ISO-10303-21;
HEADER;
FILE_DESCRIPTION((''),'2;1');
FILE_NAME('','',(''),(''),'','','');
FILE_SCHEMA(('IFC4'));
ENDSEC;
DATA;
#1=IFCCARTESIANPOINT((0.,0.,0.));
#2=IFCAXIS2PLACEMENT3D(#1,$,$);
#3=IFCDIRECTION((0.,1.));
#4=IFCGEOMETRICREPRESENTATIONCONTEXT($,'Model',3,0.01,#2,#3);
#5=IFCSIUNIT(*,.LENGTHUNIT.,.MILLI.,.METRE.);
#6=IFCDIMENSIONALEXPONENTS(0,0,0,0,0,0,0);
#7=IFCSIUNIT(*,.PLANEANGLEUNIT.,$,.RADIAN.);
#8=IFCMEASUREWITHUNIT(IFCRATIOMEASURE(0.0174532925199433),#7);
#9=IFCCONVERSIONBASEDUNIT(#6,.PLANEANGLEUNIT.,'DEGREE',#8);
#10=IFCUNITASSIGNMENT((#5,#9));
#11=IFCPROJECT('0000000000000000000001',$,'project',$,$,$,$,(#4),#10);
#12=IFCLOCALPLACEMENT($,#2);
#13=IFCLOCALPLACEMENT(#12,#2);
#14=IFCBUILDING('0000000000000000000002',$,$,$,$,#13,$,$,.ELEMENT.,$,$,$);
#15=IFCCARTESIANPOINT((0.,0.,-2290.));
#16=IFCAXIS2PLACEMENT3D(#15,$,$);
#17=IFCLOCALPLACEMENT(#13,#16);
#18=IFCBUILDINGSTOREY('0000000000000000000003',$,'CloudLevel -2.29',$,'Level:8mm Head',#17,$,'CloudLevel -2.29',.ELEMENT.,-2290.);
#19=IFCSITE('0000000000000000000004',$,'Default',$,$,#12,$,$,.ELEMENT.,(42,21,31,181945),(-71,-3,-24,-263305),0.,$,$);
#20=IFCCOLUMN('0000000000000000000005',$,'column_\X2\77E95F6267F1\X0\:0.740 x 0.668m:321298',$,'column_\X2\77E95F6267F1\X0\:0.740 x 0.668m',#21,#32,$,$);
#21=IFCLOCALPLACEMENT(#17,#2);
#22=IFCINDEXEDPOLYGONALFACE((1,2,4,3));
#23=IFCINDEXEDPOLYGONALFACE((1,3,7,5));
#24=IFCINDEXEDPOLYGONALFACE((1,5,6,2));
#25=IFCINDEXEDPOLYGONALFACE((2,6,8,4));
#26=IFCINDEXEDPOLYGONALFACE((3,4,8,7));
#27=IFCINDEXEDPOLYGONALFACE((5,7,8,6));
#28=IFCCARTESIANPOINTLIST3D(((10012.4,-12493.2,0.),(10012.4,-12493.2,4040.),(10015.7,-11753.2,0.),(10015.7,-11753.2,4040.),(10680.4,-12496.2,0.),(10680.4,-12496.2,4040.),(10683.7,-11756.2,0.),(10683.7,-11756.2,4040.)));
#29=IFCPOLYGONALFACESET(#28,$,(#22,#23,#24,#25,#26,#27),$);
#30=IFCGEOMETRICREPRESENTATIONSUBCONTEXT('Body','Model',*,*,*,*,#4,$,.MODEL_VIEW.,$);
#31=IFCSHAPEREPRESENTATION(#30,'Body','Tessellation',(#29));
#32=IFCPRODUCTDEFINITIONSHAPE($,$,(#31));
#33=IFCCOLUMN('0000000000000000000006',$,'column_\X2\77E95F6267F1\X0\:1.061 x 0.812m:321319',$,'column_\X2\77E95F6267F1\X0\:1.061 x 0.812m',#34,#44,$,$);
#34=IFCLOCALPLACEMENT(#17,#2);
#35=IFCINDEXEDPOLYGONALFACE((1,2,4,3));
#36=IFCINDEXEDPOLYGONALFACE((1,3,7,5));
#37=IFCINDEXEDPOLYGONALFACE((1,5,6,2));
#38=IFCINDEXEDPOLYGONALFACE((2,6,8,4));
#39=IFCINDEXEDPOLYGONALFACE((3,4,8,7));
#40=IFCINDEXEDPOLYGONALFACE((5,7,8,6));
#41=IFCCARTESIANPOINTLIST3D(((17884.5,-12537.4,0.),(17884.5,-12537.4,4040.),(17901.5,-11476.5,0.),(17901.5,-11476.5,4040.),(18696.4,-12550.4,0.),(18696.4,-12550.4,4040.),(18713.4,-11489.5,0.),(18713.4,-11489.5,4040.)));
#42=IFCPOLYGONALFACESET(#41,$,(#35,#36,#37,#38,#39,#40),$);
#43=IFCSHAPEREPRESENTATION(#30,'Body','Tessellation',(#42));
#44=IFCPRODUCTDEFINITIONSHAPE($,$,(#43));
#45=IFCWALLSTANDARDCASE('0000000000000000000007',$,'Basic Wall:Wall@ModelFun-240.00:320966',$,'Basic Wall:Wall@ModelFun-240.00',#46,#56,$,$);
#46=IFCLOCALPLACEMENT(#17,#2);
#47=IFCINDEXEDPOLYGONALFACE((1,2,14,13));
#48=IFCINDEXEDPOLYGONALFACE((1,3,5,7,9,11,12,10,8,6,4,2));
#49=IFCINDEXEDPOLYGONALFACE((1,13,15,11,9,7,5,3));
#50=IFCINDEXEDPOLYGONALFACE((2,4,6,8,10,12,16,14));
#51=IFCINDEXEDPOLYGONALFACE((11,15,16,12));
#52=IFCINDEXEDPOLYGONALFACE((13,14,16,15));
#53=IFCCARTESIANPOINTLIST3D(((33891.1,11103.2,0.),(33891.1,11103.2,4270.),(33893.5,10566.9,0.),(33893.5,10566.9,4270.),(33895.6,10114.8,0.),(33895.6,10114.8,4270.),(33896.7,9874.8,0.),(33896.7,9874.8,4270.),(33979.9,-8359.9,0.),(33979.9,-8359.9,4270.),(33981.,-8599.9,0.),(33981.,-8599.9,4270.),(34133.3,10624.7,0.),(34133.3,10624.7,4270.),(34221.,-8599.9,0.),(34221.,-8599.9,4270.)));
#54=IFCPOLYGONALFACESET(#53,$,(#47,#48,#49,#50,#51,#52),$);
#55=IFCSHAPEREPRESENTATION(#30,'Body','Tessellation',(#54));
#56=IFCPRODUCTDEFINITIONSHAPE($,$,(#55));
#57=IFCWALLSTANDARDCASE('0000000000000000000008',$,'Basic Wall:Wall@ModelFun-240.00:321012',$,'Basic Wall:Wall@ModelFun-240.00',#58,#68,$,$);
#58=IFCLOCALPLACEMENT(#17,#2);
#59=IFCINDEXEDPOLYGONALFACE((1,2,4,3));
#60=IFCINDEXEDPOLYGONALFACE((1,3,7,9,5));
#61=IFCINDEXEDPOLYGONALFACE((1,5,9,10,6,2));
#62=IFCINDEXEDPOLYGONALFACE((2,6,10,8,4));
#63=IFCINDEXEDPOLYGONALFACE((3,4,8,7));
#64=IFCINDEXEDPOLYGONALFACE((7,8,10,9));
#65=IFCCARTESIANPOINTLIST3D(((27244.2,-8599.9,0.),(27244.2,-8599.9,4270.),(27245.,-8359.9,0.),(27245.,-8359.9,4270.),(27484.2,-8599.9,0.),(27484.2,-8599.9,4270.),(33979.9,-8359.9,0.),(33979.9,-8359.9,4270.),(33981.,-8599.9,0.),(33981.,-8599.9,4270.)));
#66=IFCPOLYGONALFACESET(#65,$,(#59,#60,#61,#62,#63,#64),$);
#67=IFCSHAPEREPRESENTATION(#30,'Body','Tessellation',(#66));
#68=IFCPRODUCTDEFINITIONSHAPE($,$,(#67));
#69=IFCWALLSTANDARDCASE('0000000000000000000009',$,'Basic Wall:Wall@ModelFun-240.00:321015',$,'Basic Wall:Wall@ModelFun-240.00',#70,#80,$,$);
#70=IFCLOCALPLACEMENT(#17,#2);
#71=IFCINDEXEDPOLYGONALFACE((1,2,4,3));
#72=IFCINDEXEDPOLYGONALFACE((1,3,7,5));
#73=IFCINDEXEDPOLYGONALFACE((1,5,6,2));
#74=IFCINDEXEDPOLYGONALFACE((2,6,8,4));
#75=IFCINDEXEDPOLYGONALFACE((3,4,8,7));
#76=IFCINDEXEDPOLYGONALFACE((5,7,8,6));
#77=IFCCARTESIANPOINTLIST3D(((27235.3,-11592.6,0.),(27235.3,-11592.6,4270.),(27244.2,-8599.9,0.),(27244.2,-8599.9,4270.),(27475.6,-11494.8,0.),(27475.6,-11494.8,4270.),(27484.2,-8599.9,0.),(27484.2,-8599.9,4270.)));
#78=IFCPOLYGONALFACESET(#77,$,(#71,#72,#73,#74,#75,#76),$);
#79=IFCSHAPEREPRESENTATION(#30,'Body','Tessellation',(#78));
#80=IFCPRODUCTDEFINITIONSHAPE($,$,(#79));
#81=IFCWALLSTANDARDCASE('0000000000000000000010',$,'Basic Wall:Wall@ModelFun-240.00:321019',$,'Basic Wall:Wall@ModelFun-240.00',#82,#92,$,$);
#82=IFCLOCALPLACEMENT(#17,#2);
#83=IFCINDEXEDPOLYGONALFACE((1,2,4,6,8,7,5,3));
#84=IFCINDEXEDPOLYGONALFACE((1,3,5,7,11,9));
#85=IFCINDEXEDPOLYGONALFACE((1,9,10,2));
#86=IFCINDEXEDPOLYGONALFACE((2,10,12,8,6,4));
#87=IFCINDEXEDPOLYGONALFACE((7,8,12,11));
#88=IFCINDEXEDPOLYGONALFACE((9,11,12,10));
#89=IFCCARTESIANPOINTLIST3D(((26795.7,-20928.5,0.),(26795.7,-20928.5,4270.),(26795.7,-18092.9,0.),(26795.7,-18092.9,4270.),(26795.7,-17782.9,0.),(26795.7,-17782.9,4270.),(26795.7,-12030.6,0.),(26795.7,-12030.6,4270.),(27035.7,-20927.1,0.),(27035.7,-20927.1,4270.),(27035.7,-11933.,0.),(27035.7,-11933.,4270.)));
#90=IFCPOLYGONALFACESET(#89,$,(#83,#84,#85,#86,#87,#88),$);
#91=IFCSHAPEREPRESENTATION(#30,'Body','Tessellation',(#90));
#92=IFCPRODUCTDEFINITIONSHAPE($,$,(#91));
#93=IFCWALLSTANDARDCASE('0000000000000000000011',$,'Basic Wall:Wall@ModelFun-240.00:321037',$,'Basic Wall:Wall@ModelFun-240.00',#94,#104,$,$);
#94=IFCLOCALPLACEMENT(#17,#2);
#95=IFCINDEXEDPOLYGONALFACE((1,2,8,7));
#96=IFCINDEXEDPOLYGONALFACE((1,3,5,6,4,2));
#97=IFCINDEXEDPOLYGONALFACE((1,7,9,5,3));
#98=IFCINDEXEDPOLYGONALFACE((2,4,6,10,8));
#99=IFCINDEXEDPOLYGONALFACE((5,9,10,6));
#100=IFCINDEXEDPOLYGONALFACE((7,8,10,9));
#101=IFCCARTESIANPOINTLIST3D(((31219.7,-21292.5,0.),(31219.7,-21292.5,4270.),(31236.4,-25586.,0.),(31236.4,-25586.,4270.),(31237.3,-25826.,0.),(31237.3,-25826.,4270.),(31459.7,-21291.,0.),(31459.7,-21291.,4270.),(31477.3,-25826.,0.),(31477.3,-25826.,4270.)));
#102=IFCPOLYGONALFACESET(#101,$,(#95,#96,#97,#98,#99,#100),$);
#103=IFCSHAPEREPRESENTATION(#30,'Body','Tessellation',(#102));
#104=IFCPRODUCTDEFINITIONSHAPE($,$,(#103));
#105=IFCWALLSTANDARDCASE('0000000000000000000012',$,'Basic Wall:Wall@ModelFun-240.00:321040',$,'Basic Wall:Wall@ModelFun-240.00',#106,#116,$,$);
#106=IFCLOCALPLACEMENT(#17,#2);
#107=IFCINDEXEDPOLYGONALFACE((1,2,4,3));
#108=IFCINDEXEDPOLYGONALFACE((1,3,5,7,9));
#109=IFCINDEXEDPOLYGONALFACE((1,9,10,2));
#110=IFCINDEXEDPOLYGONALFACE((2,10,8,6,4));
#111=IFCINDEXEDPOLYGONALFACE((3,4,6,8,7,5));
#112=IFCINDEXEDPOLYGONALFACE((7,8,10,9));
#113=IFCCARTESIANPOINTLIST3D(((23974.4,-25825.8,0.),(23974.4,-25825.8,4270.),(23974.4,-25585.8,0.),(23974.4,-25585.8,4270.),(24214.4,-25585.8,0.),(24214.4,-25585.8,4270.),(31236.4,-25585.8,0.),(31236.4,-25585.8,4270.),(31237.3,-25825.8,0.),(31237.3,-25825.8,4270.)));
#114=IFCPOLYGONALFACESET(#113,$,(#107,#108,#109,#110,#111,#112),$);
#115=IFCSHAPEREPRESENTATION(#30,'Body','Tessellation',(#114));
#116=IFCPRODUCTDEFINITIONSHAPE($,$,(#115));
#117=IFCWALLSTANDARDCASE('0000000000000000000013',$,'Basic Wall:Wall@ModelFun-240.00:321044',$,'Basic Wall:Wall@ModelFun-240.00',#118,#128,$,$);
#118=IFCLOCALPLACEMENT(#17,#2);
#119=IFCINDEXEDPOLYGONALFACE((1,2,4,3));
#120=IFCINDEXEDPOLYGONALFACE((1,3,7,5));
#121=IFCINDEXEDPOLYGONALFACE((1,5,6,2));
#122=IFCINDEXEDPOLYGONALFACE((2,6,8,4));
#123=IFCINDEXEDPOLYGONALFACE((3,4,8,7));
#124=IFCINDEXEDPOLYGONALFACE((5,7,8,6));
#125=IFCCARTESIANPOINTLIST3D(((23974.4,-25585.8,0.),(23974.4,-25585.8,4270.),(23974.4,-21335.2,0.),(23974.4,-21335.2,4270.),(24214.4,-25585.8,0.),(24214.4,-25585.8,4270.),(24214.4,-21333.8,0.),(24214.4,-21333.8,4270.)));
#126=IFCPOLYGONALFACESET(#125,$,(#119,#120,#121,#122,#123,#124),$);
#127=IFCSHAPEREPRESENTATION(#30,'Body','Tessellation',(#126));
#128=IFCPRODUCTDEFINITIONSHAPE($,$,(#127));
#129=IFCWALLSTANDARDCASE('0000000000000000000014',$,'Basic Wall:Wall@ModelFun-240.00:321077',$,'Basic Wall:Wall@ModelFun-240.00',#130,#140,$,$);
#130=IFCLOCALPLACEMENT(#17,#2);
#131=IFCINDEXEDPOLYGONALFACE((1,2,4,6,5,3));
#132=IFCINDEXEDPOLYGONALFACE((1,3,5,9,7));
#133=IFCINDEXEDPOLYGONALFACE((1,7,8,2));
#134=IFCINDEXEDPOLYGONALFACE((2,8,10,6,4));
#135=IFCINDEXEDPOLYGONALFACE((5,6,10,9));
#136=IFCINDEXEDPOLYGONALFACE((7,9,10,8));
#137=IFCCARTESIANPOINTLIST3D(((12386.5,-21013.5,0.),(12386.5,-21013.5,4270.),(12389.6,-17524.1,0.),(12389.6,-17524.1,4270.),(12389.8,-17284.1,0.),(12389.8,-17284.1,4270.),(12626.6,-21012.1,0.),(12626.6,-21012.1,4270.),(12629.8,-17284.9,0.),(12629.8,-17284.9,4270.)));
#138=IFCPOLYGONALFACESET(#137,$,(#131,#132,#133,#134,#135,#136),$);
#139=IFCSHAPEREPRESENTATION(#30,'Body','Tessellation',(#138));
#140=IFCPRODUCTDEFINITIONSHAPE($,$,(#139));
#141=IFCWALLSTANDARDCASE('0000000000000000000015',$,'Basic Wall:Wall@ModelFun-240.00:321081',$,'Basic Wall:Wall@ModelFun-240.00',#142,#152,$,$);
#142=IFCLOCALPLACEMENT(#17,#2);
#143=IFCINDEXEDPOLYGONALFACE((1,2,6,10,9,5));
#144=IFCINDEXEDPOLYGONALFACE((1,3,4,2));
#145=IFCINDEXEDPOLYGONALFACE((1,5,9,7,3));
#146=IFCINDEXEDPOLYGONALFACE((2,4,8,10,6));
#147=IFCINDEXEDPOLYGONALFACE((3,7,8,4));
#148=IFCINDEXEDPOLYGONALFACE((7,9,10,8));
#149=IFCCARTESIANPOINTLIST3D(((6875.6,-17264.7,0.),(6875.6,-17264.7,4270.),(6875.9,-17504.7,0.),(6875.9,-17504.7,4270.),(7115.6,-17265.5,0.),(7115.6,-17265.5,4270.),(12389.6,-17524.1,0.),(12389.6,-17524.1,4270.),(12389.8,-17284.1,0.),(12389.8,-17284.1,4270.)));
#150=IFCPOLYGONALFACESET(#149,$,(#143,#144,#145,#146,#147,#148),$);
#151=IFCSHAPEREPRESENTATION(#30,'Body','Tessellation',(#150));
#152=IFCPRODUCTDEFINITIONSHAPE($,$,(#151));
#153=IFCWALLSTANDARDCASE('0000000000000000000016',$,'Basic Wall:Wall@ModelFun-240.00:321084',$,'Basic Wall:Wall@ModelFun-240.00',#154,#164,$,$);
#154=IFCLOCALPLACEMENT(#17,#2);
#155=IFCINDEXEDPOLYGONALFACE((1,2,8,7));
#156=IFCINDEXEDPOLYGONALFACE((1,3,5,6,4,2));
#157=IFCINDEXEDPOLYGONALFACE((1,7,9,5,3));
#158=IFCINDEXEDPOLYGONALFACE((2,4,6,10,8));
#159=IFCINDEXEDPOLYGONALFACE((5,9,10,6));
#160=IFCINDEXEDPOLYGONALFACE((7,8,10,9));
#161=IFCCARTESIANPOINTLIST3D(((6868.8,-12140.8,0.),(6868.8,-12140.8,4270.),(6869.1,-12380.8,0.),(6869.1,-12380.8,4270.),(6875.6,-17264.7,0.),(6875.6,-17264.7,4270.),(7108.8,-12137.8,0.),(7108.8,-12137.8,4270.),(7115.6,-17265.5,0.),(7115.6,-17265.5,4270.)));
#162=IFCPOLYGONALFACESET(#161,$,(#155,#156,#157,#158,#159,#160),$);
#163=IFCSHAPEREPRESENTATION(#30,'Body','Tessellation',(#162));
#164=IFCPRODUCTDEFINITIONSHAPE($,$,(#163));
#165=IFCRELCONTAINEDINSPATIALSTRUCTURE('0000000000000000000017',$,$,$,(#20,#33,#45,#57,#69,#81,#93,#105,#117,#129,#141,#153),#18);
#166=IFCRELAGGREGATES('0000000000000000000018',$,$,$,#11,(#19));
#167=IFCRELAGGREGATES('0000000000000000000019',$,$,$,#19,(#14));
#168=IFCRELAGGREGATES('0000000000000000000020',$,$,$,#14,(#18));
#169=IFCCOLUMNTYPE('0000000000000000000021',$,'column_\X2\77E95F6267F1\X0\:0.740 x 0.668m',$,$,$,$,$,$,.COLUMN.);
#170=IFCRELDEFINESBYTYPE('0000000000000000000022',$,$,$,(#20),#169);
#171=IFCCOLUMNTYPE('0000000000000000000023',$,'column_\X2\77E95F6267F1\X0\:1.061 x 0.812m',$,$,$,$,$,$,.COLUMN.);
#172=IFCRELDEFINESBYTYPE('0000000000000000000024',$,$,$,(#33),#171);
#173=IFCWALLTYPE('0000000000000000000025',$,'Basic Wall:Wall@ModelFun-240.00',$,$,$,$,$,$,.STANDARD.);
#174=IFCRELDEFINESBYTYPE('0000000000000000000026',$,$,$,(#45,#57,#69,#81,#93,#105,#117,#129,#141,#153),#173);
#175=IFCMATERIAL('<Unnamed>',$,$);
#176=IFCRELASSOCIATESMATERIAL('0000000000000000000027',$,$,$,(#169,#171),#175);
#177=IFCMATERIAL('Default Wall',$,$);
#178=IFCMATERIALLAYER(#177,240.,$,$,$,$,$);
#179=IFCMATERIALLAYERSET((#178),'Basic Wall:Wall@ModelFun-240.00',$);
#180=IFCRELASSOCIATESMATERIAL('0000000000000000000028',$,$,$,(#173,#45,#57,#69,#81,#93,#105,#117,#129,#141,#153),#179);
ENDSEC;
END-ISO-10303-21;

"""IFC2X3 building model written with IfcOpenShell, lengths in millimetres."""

from ifc_helpers import new_model, entity, si_unit, converted_unit, direction, frame, origin, origin_2d_with_axis, place, context, subcontext, project, spatial, polyline, rectangle, outline, extrude, source, transform, mapped, material, layer, layer_set, layer_usage, type_object, type_shapes, element, save


model = new_model("IFC2X3")

# Units and contexts
model_context = context("Model", 3, precision=0.01, world=origin(), true_north=direction((0.0, 1.0)))
body_context = subcontext(model_context, "Body", "Model", "MODEL_VIEW")
ifc_project = project(units=[si_unit("LENGTHUNIT", "METRE", prefix="MILLI"), converted_unit("PLANEANGLEUNIT", "DEGREE", entity("IfcRatioMeasure", 0.0174532925199433), si_unit("PLANEANGLEUNIT", "RADIAN"), dimensions=[0, 0, 0, 0, 0, 0, 0])], contexts=[model_context])

# Site, building, storey
site_placement = place(None, origin())
site = spatial("IfcSite", under=ifc_project, at=site_placement, Name="Default", CompositionType="ELEMENT", RefLatitude=(42, 21, 31, 181945), RefLongitude=(-71, -3, -24, -263305), RefElevation=0.0)
building_placement = place(site_placement, origin())
building = spatial("IfcBuilding", under=site, at=building_placement, CompositionType="ELEMENT")
storey_placement = place(building_placement, frame((0.0, 0.0, -2290.0)))
storey = spatial("IfcBuildingStorey", under=building, at=storey_placement, Name="CloudLevel -2.29", ObjectType="Level:8mm Head", LongName="CloudLevel -2.29", CompositionType="ELEMENT", Elevation=-2290.0)

# Columns
ifc_material_1 = material(Name="<Unnamed>")
column_type_1 = type_object("IfcColumnType", Name="column_矩形柱:0.740 x 0.668m", PredefinedType="COLUMN", material=ifc_material_1)
shared_shape_1 = source(origin(), body_context, "Body", "SweptSolid", [
    extrude(rectangle(XDim=668.0, YDim=740.0, at=origin_2d_with_axis()), frame((0.0, 0.0, -2290.0), z_axis=(0.0, 0.0, 1.0), x_axis=(0.0, -1.0, 0.0)), (0.0, 0.0, 1.0), 4040.0),
])
type_shapes(column_type_1, [shared_shape_1])
column_1_placement = place(storey_placement, frame((10348.0, -12124.7, 2290.0), z_axis=(0.0, 0.0, 1.0), x_axis=(0.004488, 0.99999, 0.0)))
element("IfcColumn", 1, at=column_1_placement, inside=storey, type_object=column_type_1, Name="column_矩形柱:0.740 x 0.668m:321298", ObjectType="column_矩形柱:0.740 x 0.668m", context=body_context, shape_type="MappedRepresentation", body=[
    mapped(shared_shape_1, transform((0.0, 0.0, 0.0), scale=1.0)),
])
column_type_2 = type_object("IfcColumnType", Name="column_矩形柱:1.061 x 0.812m", PredefinedType="COLUMN", material=ifc_material_1)
shared_shape_2 = source(origin(), body_context, "Body", "SweptSolid", [
    extrude(rectangle(XDim=812.0, YDim=1061.0, at=origin_2d_with_axis()), frame((0.0, 0.0, -2290.0), z_axis=(0.0, 0.0, 1.0), x_axis=(0.0, -1.0, 0.0)), (0.0, 0.0, 1.0), 4040.0),
])
type_shapes(column_type_2, [shared_shape_2])
column_2_placement = place(storey_placement, frame((18298.9, -12013.4, 2290.0), z_axis=(0.0, 0.0, 1.0), x_axis=(0.01605, 0.999871, 0.0)))
element("IfcColumn", 2, at=column_2_placement, inside=storey, type_object=column_type_2, Name="column_矩形柱:1.061 x 0.812m:321319", ObjectType="column_矩形柱:1.061 x 0.812m", context=body_context, shape_type="MappedRepresentation", body=[
    mapped(shared_shape_2, transform((0.0, 0.0, 0.0), scale=1.0)),
])

# Walls
ifc_material_2 = material(Name="Default Wall")
ifc_layer_1 = layer(ifc_material_2, 240.0)
ifc_layer_set_1 = layer_set([ifc_layer_1], Name="Basic Wall:Wall@ModelFun-240.00")
ifc_layer_usage_1 = layer_usage(ifc_layer_set_1, "AXIS2", "NEGATIVE", 120.0)
wall_type_1 = type_object("IfcWallType", Name="Basic Wall:Wall@ModelFun-240.00", PredefinedType="STANDARD", material=ifc_layer_set_1)
wall_1_placement = place(storey_placement, frame((34101.0, -8600.4, 0.0), z_axis=(0.0, 0.0, 1.0), x_axis=(-0.004564, 0.99999, 0.0)))
element("IfcWallStandardCase", 3, at=wall_1_placement, inside=storey, type_object=wall_type_1, material=ifc_layer_usage_1, Name="Basic Wall:Wall@ModelFun-240.00:320966", ObjectType="Basic Wall:Wall@ModelFun-240.00", context=body_context, shape_type="SweptSolid", body=[
    extrude(outline(polyline([(19224.8, -120.0), (19704.4, 120.0), (19168.1, 120.0), (18716.0, 120.0), (18476.0, 120.0), (241.1, 120.0), (1.1, 120.0), (0.0, -120.0), (19224.8, -120.0)])), origin(), (0.0, 0.0, 1.0), 4270.0),
])
ifc_layer_usage_2 = layer_usage(ifc_layer_set_1, "AXIS2", "NEGATIVE", 120.0)
wall_2_placement = place(storey_placement, frame((33981.0, -8479.9, 0.0), z_axis=(0.0, 0.0, 1.0), x_axis=(-1.0, 0.0, 0.0)))
element("IfcWallStandardCase", 4, at=wall_2_placement, inside=storey, type_object=wall_type_1, material=ifc_layer_usage_2, Name="Basic Wall:Wall@ModelFun-240.00:321012", ObjectType="Basic Wall:Wall@ModelFun-240.00", context=body_context, shape_type="SweptSolid", body=[
    extrude(outline(polyline([(6736.0, -120.0), (6736.8, 120.0), (6496.8, 120.0), (0.0, 120.0), (1.1, -120.0), (6736.0, -120.0)])), origin(), (0.0, 0.0, 1.0), 4270.0),
])
ifc_layer_usage_3 = layer_usage(ifc_layer_set_1, "AXIS2", "NEGATIVE", 120.0)
wall_3_placement = place(storey_placement, frame((27355.3, -11593.0, 0.0), z_axis=(0.0, 0.0, 1.0), x_axis=(0.002989, 0.999996, 0.0)))
element("IfcWallStandardCase", 5, at=wall_3_placement, inside=storey, type_object=wall_type_1, material=ifc_layer_usage_3, Name="Basic Wall:Wall@ModelFun-240.00:321015", ObjectType="Basic Wall:Wall@ModelFun-240.00", context=body_context, shape_type="SweptSolid", body=[
    extrude(outline(polyline([(2993.4, -120.0), (2992.7, 120.0), (0.0, 120.0), (98.5, -120.0), (2993.4, -120.0)])), origin(), (0.0, 0.0, 1.0), 4270.0),
])
ifc_layer_usage_4 = layer_usage(ifc_layer_set_1, "AXIS2", "NEGATIVE", 120.0)
wall_4_placement = place(storey_placement, frame((26915.7, -20928.5, 0.0), z_axis=(0.0, 0.0, 1.0), x_axis=(0.0, 1.0, 0.0)))
element("IfcWallStandardCase", 6, at=wall_4_placement, inside=storey, type_object=wall_type_1, material=ifc_layer_usage_4, Name="Basic Wall:Wall@ModelFun-240.00:321019", ObjectType="Basic Wall:Wall@ModelFun-240.00", context=body_context, shape_type="SweptSolid", body=[
    extrude(outline(polyline([(8995.6, -120.0), (8897.9, 120.0), (3145.7, 120.0), (2835.7, 120.0), (0.0, 120.0), (1.4, -120.0), (8995.6, -120.0)])), origin(), (0.0, 0.0, 1.0), 4270.0),
])
ifc_layer_usage_5 = layer_usage(ifc_layer_set_1, "AXIS2", "NEGATIVE", 120.0)
wall_5_placement = place(storey_placement, frame((31339.7, -21291.5, 0.0), z_axis=(0.0, 0.0, 1.0), x_axis=(0.00389, -0.999992, 0.0)))
element("IfcWallStandardCase", 7, at=wall_5_placement, inside=storey, type_object=wall_type_1, material=ifc_layer_usage_5, Name="Basic Wall:Wall@ModelFun-240.00:321037", ObjectType="Basic Wall:Wall@ModelFun-240.00", context=body_context, shape_type="SweptSolid", body=[
    extrude(outline(polyline([(4534.1, -120.0), (4535.0, 120.0), (0.0, 120.0), (0.5, -120.0), (4294.1, -120.0), (4534.1, -120.0)])), origin(), (0.0, 0.0, 1.0), 4270.0),
])
ifc_layer_usage_6 = layer_usage(ifc_layer_set_1, "AXIS2", "NEGATIVE", 120.0)
wall_6_placement = place(storey_placement, frame((23974.4, -25705.8, 0.0)))
element("IfcWallStandardCase", 8, at=wall_6_placement, inside=storey, type_object=wall_type_1, material=ifc_layer_usage_6, Name="Basic Wall:Wall@ModelFun-240.00:321040", ObjectType="Basic Wall:Wall@ModelFun-240.00", context=body_context, shape_type="SweptSolid", body=[
    extrude(outline(polyline([(7263.0, -120.0), (7262.0, 120.0), (240.0, 120.0), (0.0, 120.0), (0.0, -120.0), (7263.0, -120.0)])), origin(), (0.0, 0.0, 1.0), 4270.0),
])
ifc_layer_usage_7 = layer_usage(ifc_layer_set_1, "AXIS2", "NEGATIVE", 120.0)
wall_7_placement = place(storey_placement, frame((24094.4, -21333.8, 0.0), z_axis=(0.0, 0.0, 1.0), x_axis=(0.0, -1.0, 0.0)))
element("IfcWallStandardCase", 9, at=wall_7_placement, inside=storey, type_object=wall_type_1, material=ifc_layer_usage_7, Name="Basic Wall:Wall@ModelFun-240.00:321044", ObjectType="Basic Wall:Wall@ModelFun-240.00", context=body_context, shape_type="SweptSolid", body=[
    extrude(outline(polyline([(4252.0, -120.0), (4252.0, 120.0), (0.0, 120.0), (1.4, -120.0), (4252.0, -120.0)])), origin(), (0.0, 0.0, 1.0), 4270.0),
])
ifc_layer_usage_8 = layer_usage(ifc_layer_set_1, "AXIS2", "NEGATIVE", 120.0)
wall_8_placement = place(storey_placement, frame((12506.5, -21013.6, 0.0), z_axis=(0.0, 0.0, 1.0), x_axis=(0.000866, 1.0, 0.0)))
element("IfcWallStandardCase", 10, at=wall_8_placement, inside=storey, type_object=wall_type_1, material=ifc_layer_usage_8, Name="Basic Wall:Wall@ModelFun-240.00:321077", ObjectType="Basic Wall:Wall@ModelFun-240.00", context=body_context, shape_type="SweptSolid", body=[
    extrude(outline(polyline([(3728.8, -120.0), (3729.4, 120.0), (3489.4, 120.0), (0.0, 120.0), (1.6, -120.0), (3728.8, -120.0)])), origin(), (0.0, 0.0, 1.0), 4270.0),
])
ifc_layer_usage_9 = layer_usage(ifc_layer_set_1, "AXIS2", "NEGATIVE", 120.0)
wall_9_placement = place(storey_placement, frame((12390.0, -17404.1, 0.0), z_axis=(0.0, 0.0, 1.0), x_axis=(-0.999994, 0.003516, 0.0)))
element("IfcWallStandardCase", 11, at=wall_9_placement, inside=storey, type_object=wall_type_1, material=ifc_layer_usage_9, Name="Basic Wall:Wall@ModelFun-240.00:321081", ObjectType="Basic Wall:Wall@ModelFun-240.00", context=body_context, shape_type="SweptSolid", body=[
    extrude(outline(polyline([(5514.9, -120.0), (5513.7, 120.0), (0.0, 120.0), (0.6, -120.0), (5274.9, -120.0), (5514.9, -120.0)])), origin(), (0.0, 0.0, 1.0), 4270.0),
])
ifc_layer_usage_10 = layer_usage(ifc_layer_set_1, "AXIS2", "NEGATIVE", 120.0)
wall_10_placement = place(storey_placement, frame((6988.8, -12137.9, 0.0), z_axis=(0.0, 0.0, 1.0), x_axis=(0.001329, -0.999999, 0.0)))
element("IfcWallStandardCase", 12, at=wall_10_placement, inside=storey, type_object=wall_type_1, material=ifc_layer_usage_10, Name="Basic Wall:Wall@ModelFun-240.00:321084", ObjectType="Basic Wall:Wall@ModelFun-240.00", context=body_context, shape_type="SweptSolid", body=[
    extrude(outline(polyline([(5126.6, -120.0), (5127.8, 120.0), (0.0, 120.0), (2.7, -120.0), (242.7, -120.0), (5126.6, -120.0)])), origin(), (0.0, 0.0, 1.0), 4270.0),
])

save(model, "model.ifc")
